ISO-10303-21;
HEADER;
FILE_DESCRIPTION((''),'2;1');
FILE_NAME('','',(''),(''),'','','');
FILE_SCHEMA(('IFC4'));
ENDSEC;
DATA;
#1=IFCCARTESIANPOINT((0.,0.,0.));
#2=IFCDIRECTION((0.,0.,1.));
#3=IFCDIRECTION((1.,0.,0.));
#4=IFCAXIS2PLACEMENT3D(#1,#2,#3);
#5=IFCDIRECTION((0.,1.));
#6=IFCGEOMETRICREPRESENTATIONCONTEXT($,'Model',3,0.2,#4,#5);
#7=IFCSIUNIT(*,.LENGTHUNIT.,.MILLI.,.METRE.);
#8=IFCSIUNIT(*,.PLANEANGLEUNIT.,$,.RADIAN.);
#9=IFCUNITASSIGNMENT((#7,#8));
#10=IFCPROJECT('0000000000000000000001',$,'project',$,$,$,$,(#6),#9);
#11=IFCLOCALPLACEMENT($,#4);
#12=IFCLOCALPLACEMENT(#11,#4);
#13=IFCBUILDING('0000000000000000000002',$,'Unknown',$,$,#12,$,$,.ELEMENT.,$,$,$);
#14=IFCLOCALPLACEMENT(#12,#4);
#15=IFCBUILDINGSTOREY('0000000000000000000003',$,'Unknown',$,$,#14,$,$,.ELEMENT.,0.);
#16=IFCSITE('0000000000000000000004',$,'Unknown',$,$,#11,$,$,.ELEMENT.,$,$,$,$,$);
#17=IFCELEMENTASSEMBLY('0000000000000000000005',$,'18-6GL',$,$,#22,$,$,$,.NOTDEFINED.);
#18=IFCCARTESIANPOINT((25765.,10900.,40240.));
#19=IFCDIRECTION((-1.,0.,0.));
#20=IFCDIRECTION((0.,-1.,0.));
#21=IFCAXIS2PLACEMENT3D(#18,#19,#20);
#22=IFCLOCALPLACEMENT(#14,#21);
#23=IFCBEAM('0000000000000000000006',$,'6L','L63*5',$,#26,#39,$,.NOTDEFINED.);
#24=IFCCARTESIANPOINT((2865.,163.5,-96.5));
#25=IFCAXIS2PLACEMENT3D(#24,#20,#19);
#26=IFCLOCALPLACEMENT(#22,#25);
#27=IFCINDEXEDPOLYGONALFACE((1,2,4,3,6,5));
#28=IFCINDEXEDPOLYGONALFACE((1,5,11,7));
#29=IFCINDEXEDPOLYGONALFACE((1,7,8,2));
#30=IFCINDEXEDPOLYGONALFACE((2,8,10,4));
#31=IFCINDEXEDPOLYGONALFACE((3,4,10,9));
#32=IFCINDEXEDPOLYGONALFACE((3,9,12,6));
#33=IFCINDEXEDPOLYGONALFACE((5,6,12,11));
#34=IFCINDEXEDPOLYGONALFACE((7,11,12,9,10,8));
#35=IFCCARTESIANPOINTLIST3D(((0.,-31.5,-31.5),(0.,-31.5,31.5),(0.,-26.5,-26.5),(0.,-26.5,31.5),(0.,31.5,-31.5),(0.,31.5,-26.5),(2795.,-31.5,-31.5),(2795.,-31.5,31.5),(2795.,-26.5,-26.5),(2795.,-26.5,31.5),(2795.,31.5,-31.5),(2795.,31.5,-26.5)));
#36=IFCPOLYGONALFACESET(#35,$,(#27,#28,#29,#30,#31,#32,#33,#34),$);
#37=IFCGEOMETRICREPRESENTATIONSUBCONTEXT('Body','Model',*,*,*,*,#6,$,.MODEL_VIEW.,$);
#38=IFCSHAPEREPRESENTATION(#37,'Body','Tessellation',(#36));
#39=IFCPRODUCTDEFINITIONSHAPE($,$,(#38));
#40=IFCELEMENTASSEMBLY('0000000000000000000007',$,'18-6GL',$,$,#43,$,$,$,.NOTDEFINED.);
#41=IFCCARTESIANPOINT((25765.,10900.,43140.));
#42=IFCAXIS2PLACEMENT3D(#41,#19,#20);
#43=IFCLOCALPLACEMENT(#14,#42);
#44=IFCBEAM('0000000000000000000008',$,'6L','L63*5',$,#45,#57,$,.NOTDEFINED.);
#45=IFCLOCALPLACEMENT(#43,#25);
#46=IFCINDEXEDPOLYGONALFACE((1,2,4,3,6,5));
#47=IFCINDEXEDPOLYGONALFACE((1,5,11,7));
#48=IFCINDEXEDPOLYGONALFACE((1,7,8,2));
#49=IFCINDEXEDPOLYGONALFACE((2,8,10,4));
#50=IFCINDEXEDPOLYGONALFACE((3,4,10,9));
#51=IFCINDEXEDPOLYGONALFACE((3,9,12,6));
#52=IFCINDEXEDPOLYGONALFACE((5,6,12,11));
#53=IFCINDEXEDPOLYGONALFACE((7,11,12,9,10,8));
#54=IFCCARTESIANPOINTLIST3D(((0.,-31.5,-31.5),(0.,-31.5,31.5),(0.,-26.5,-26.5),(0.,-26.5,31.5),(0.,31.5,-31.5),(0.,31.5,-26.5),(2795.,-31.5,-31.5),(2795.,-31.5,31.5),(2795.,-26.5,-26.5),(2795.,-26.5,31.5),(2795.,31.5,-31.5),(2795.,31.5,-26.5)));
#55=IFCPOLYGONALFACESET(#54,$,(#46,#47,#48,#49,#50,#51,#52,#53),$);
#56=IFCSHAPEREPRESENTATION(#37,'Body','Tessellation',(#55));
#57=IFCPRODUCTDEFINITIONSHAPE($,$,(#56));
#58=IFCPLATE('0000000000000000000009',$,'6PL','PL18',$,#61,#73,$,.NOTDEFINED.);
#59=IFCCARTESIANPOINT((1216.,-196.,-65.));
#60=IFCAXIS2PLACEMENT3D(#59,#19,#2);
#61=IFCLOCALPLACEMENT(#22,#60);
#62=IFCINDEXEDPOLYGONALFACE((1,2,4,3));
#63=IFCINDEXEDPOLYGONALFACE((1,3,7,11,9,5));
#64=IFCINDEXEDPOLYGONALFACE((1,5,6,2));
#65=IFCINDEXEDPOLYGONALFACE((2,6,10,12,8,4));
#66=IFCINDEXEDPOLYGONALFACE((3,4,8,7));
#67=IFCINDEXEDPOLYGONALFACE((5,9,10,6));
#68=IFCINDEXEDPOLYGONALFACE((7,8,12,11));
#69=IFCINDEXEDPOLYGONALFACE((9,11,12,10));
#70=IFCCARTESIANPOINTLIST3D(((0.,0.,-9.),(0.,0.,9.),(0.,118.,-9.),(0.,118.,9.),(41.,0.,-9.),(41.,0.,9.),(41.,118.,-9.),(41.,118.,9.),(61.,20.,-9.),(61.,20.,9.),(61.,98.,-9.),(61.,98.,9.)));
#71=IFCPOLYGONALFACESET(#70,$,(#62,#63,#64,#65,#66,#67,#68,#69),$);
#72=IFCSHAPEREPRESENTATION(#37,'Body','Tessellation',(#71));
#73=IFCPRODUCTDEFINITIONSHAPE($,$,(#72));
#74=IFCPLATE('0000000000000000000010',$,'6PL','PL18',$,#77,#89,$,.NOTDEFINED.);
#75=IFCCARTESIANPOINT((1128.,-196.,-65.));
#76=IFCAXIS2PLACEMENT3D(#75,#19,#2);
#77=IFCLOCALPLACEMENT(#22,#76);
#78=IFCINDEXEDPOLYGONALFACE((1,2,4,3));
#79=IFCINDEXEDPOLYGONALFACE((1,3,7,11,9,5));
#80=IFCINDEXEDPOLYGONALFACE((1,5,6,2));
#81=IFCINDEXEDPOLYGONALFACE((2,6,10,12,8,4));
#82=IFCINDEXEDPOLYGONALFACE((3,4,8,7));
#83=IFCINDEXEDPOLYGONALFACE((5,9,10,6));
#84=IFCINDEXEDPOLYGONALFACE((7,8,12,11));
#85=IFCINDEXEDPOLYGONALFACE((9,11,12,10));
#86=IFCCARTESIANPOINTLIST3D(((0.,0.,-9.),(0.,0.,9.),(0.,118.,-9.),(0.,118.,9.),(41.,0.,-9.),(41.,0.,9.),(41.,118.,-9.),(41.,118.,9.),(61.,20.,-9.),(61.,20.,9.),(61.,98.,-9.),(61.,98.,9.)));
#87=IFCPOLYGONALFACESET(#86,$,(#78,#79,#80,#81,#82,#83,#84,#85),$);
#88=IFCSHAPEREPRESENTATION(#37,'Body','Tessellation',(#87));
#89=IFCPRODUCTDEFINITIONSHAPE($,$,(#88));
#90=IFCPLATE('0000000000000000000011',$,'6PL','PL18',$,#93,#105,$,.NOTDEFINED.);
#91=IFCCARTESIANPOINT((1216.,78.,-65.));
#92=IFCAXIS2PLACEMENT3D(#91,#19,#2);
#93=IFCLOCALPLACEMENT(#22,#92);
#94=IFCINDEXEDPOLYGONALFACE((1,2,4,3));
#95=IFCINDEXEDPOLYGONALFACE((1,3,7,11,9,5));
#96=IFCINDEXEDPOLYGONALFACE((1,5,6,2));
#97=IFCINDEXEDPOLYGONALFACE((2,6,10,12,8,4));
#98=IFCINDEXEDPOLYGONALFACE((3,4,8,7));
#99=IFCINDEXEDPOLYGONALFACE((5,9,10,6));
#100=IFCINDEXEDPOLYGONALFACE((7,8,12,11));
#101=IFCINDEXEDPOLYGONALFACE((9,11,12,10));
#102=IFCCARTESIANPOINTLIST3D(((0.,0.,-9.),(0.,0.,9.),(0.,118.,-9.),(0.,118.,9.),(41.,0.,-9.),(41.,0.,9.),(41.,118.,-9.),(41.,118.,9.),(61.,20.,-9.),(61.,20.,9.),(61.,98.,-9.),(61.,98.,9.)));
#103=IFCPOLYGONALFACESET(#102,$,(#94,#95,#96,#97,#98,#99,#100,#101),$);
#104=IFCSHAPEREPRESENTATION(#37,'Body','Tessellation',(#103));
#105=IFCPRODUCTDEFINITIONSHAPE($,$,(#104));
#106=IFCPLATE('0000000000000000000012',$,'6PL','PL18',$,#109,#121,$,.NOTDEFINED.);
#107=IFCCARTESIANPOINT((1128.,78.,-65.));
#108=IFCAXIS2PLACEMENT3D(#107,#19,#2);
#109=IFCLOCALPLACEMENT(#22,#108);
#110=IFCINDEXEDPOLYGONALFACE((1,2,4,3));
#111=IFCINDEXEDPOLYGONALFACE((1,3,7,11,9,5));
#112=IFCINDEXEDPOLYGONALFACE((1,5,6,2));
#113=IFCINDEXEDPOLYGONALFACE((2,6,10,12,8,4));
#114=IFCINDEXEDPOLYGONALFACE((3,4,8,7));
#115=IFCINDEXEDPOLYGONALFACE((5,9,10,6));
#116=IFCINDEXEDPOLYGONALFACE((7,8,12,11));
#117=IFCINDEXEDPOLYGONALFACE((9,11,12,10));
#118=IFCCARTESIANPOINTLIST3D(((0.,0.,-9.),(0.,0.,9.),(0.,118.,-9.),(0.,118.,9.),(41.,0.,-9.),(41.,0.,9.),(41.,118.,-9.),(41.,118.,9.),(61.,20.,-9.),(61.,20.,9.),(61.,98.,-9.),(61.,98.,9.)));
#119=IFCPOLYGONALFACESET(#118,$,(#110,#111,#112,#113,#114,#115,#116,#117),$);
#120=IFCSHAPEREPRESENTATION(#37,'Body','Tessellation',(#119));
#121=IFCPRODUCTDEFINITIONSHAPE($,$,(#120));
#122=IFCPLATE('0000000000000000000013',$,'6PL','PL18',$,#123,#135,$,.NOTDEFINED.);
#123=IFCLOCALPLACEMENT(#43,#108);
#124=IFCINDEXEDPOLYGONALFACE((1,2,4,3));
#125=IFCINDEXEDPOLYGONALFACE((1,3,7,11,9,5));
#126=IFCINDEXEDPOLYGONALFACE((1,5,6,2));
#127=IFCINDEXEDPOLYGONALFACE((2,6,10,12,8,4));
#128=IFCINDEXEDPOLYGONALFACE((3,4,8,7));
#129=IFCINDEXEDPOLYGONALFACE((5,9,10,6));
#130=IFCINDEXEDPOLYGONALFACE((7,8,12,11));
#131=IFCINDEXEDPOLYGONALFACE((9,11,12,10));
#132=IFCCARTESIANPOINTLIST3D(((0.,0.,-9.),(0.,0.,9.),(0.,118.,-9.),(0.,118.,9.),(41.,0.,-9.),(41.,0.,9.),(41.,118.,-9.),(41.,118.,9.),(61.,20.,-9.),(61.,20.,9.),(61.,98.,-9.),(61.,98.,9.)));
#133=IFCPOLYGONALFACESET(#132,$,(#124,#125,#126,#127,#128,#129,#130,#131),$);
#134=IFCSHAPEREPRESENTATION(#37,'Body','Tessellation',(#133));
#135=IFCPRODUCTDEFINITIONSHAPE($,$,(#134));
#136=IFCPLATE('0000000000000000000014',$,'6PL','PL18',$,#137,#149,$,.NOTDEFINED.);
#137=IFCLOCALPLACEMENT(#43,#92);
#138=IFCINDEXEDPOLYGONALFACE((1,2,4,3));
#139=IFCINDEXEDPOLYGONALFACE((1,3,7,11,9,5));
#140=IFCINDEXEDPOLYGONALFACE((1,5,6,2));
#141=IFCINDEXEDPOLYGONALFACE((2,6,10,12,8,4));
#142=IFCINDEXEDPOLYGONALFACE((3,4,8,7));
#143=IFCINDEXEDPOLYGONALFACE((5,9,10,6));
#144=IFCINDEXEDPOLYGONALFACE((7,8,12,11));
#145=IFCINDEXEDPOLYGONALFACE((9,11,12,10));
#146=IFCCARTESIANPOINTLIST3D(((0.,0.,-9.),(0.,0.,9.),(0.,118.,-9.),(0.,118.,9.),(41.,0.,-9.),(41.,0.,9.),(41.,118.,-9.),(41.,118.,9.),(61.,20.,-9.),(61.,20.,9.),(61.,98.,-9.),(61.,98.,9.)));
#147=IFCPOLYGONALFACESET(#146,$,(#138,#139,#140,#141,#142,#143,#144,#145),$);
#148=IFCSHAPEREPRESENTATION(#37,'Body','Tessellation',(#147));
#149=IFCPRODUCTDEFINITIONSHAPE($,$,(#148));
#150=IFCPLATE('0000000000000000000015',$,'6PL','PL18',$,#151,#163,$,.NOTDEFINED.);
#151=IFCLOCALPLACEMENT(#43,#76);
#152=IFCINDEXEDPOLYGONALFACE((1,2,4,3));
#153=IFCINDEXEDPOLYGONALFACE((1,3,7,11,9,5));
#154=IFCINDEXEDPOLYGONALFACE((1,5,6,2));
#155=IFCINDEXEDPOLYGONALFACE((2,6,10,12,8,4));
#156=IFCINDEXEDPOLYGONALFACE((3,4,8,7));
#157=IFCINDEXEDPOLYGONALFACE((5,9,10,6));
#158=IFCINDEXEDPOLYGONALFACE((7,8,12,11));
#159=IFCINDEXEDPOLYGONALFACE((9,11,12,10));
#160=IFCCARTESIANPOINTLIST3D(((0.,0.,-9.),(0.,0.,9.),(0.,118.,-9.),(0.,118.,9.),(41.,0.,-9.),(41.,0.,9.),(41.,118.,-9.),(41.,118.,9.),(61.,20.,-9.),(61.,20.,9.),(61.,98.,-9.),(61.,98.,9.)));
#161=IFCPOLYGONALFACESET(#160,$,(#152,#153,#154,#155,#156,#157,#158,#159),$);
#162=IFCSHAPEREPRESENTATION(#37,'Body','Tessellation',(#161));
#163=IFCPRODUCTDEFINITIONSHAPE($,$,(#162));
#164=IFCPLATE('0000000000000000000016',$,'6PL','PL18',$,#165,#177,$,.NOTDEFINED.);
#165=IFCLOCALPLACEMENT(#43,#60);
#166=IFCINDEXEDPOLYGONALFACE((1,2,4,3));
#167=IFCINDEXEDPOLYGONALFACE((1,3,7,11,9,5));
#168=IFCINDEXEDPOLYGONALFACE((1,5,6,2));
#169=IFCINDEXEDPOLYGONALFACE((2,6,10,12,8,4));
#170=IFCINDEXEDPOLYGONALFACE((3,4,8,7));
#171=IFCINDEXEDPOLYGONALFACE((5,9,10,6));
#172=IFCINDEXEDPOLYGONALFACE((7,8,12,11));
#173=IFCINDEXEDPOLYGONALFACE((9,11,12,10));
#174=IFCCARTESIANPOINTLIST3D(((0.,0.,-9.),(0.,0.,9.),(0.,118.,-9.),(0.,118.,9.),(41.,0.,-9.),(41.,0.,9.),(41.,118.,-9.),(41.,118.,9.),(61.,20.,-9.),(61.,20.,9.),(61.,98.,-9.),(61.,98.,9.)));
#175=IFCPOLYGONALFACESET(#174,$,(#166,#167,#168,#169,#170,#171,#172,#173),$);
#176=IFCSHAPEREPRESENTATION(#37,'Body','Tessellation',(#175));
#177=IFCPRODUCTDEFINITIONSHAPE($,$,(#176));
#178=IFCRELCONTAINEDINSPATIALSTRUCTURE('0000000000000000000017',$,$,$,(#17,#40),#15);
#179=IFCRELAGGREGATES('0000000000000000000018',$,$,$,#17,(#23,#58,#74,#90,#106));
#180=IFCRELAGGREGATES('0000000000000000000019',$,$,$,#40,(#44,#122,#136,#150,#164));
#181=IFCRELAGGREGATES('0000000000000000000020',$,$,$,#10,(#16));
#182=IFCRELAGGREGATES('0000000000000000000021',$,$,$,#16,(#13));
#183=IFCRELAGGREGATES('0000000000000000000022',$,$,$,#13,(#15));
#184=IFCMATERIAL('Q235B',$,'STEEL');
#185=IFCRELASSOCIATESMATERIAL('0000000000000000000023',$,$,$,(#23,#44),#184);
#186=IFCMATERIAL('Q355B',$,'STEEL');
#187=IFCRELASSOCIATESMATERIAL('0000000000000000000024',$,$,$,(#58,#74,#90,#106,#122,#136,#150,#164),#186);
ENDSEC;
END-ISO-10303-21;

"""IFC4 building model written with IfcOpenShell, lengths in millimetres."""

from ifc_helpers import new_model, si_unit, direction, frame, origin_with_axes, place, context, subcontext, project, spatial, line, indexed_curve, outline, extrude, material, element, aggregate, save


model = new_model("IFC4")

# Units and contexts
model_context = context("Model", 3, precision=0.2, world=origin_with_axes(), true_north=direction((0.0, 1.0)))
body_context = subcontext(model_context, "Body", "Model", "MODEL_VIEW")
ifc_project = project(units=[si_unit("LENGTHUNIT", "METRE", prefix="MILLI"), si_unit("PLANEANGLEUNIT", "RADIAN")], contexts=[model_context])

# Site, building, storey
site_placement = place(None, origin_with_axes())
site = spatial("IfcSite", under=ifc_project, at=site_placement, Name="Unknown", CompositionType="ELEMENT")
building_placement = place(site_placement, origin_with_axes())
building = spatial("IfcBuilding", under=site, at=building_placement, Name="Unknown", CompositionType="ELEMENT")
storey_placement = place(building_placement, origin_with_axes())
storey = spatial("IfcBuildingStorey", under=building, at=storey_placement, Name="Unknown", CompositionType="ELEMENT", Elevation=0.0)

# Shared definitions
ifc_material_1 = material(Name="Q355B", Category="STEEL")

# Element assemblies, beams
assembly_1_placement = place(storey_placement, frame((25765.0, 10900.0, 40240.0), z_axis=(-1.0, 0.0, 0.0), x_axis=(0.0, -1.0, 0.0)))
assembly_1 = element("IfcElementAssembly", 1, at=assembly_1_placement, inside=storey, Name="18-6GL", PredefinedType="NOTDEFINED")
ifc_material_2 = material(Name="Q235B", Category="STEEL")
beam_1_placement = place(assembly_1_placement, frame((2865.0, 163.5, -96.5), z_axis=(0.0, -1.0, 0.0), x_axis=(-1.0, 0.0, 0.0)))
beam_1 = element("IfcBeam", 2, at=beam_1_placement, material=ifc_material_2, Name="6L", Description="L63*5", PredefinedType="NOTDEFINED", context=body_context, shape_type="SolidModel", body=[
    extrude(outline(indexed_curve([(-31.5, -31.5), (31.5, -31.5), (31.5, -26.5), (-26.5, -26.5), (-26.5, 31.5), (-31.5, 31.5)], segments=[line(1, 2, 3, 4, 5, 6, 1)])), frame((0.0, 0.0, 0.0), z_axis=(-1.0, 0.0, 0.0), x_axis=(0.0, 0.0, 1.0)), (0.0, 0.0, -1.0), 2795.0),
])
assembly_2_placement = place(storey_placement, frame((25765.0, 10900.0, 43140.0), z_axis=(-1.0, 0.0, 0.0), x_axis=(0.0, -1.0, 0.0)))
assembly_2 = element("IfcElementAssembly", 3, at=assembly_2_placement, inside=storey, Name="18-6GL", PredefinedType="NOTDEFINED")
beam_2_placement = place(assembly_2_placement, frame((2865.0, 163.5, -96.5), z_axis=(0.0, -1.0, 0.0), x_axis=(-1.0, 0.0, 0.0)))
beam_2 = element("IfcBeam", 4, at=beam_2_placement, material=ifc_material_2, Name="6L", Description="L63*5", PredefinedType="NOTDEFINED", context=body_context, shape_type="SolidModel", body=[
    extrude(outline(indexed_curve([(-31.5, -31.5), (31.5, -31.5), (31.5, -26.5), (-26.5, -26.5), (-26.5, 31.5), (-31.5, 31.5)], segments=[line(1, 2, 3, 4, 5, 6, 1)])), frame((0.0, 0.0, 0.0), z_axis=(-1.0, 0.0, 0.0), x_axis=(0.0, 0.0, 1.0)), (0.0, 0.0, -1.0), 2795.0),
])

# Plates
plate_1_placement = place(assembly_1_placement, frame((1216.0, -196.0, -65.0), z_axis=(-1.0, 0.0, 0.0), x_axis=(0.0, 0.0, 1.0)))
plate_1 = element("IfcPlate", 5, at=plate_1_placement, material=ifc_material_1, Name="6PL", Description="PL18", PredefinedType="NOTDEFINED", context=body_context, shape_type="SolidModel", body=[
    extrude(outline(indexed_curve([(0.0, 0.0), (41.0, 0.0), (61.0, 20.0), (61.0, 98.0), (41.0, 118.0), (0.0, 118.0)], segments=[line(1, 2, 3, 4, 5, 6, 1)])), frame((0.0, 0.0, 9.0), z_axis=(0.0, 0.0, 1.0), x_axis=(1.0, 0.0, 0.0)), (0.0, 0.0, -1.0), 18.0),
])
plate_2_placement = place(assembly_1_placement, frame((1128.0, -196.0, -65.0), z_axis=(-1.0, 0.0, 0.0), x_axis=(0.0, 0.0, 1.0)))
plate_2 = element("IfcPlate", 6, at=plate_2_placement, material=ifc_material_1, Name="6PL", Description="PL18", PredefinedType="NOTDEFINED", context=body_context, shape_type="SolidModel", body=[
    extrude(outline(indexed_curve([(0.0, 0.0), (41.0, 0.0), (61.0, 20.0), (61.0, 98.0), (41.0, 118.0), (0.0, 118.0)], segments=[line(1, 2, 3, 4, 5, 6, 1)])), frame((0.0, 0.0, 9.0), z_axis=(0.0, 0.0, 1.0), x_axis=(1.0, 0.0, 0.0)), (0.0, 0.0, -1.0), 18.0),
])
plate_3_placement = place(assembly_1_placement, frame((1216.0, 78.0, -65.0), z_axis=(-1.0, 0.0, 0.0), x_axis=(0.0, 0.0, 1.0)))
plate_3 = element("IfcPlate", 7, at=plate_3_placement, material=ifc_material_1, Name="6PL", Description="PL18", PredefinedType="NOTDEFINED", context=body_context, shape_type="SolidModel", body=[
    extrude(outline(indexed_curve([(0.0, 0.0), (41.0, 0.0), (61.0, 20.0), (61.0, 98.0), (41.0, 118.0), (0.0, 118.0)], segments=[line(1, 2, 3, 4, 5, 6, 1)])), frame((0.0, 0.0, 9.0), z_axis=(0.0, 0.0, 1.0), x_axis=(1.0, 0.0, 0.0)), (0.0, 0.0, -1.0), 18.0),
])
plate_4_placement = place(assembly_1_placement, frame((1128.0, 78.0, -65.0), z_axis=(-1.0, 0.0, 0.0), x_axis=(0.0, 0.0, 1.0)))
plate_4 = element("IfcPlate", 8, at=plate_4_placement, material=ifc_material_1, Name="6PL", Description="PL18", PredefinedType="NOTDEFINED", context=body_context, shape_type="SolidModel", body=[
    extrude(outline(indexed_curve([(0.0, 0.0), (41.0, 0.0), (61.0, 20.0), (61.0, 98.0), (41.0, 118.0), (0.0, 118.0)], segments=[line(1, 2, 3, 4, 5, 6, 1)])), frame((0.0, 0.0, 9.0), z_axis=(0.0, 0.0, 1.0), x_axis=(1.0, 0.0, 0.0)), (0.0, 0.0, -1.0), 18.0),
])
aggregate(assembly_1, [beam_1, plate_1, plate_2, plate_3, plate_4])
plate_5_placement = place(assembly_2_placement, frame((1128.0, 78.0, -65.0), z_axis=(-1.0, 0.0, 0.0), x_axis=(0.0, 0.0, 1.0)))
plate_5 = element("IfcPlate", 9, at=plate_5_placement, material=ifc_material_1, Name="6PL", Description="PL18", PredefinedType="NOTDEFINED", context=body_context, shape_type="SolidModel", body=[
    extrude(outline(indexed_curve([(0.0, 0.0), (41.0, 0.0), (61.0, 20.0), (61.0, 98.0), (41.0, 118.0), (0.0, 118.0)], segments=[line(1, 2, 3, 4, 5, 6, 1)])), frame((0.0, 0.0, 9.0), z_axis=(0.0, 0.0, 1.0), x_axis=(1.0, 0.0, 0.0)), (0.0, 0.0, -1.0), 18.0),
])
plate_6_placement = place(assembly_2_placement, frame((1216.0, 78.0, -65.0), z_axis=(-1.0, 0.0, 0.0), x_axis=(0.0, 0.0, 1.0)))
plate_6 = element("IfcPlate", 10, at=plate_6_placement, material=ifc_material_1, Name="6PL", Description="PL18", PredefinedType="NOTDEFINED", context=body_context, shape_type="SolidModel", body=[
    extrude(outline(indexed_curve([(0.0, 0.0), (41.0, 0.0), (61.0, 20.0), (61.0, 98.0), (41.0, 118.0), (0.0, 118.0)], segments=[line(1, 2, 3, 4, 5, 6, 1)])), frame((0.0, 0.0, 9.0), z_axis=(0.0, 0.0, 1.0), x_axis=(1.0, 0.0, 0.0)), (0.0, 0.0, -1.0), 18.0),
])
plate_7_placement = place(assembly_2_placement, frame((1128.0, -196.0, -65.0), z_axis=(-1.0, 0.0, 0.0), x_axis=(0.0, 0.0, 1.0)))
plate_7 = element("IfcPlate", 11, at=plate_7_placement, material=ifc_material_1, Name="6PL", Description="PL18", PredefinedType="NOTDEFINED", context=body_context, shape_type="SolidModel", body=[
    extrude(outline(indexed_curve([(0.0, 0.0), (41.0, 0.0), (61.0, 20.0), (61.0, 98.0), (41.0, 118.0), (0.0, 118.0)], segments=[line(1, 2, 3, 4, 5, 6, 1)])), frame((0.0, 0.0, 9.0), z_axis=(0.0, 0.0, 1.0), x_axis=(1.0, 0.0, 0.0)), (0.0, 0.0, -1.0), 18.0),
])
plate_8_placement = place(assembly_2_placement, frame((1216.0, -196.0, -65.0), z_axis=(-1.0, 0.0, 0.0), x_axis=(0.0, 0.0, 1.0)))
plate_8 = element("IfcPlate", 12, at=plate_8_placement, material=ifc_material_1, Name="6PL", Description="PL18", PredefinedType="NOTDEFINED", context=body_context, shape_type="SolidModel", body=[
    extrude(outline(indexed_curve([(0.0, 0.0), (41.0, 0.0), (61.0, 20.0), (61.0, 98.0), (41.0, 118.0), (0.0, 118.0)], segments=[line(1, 2, 3, 4, 5, 6, 1)])), frame((0.0, 0.0, 9.0), z_axis=(0.0, 0.0, 1.0), x_axis=(1.0, 0.0, 0.0)), (0.0, 0.0, -1.0), 18.0),
])
aggregate(assembly_2, [beam_2, plate_5, plate_6, plate_7, plate_8])

save(model, "model.ifc")
